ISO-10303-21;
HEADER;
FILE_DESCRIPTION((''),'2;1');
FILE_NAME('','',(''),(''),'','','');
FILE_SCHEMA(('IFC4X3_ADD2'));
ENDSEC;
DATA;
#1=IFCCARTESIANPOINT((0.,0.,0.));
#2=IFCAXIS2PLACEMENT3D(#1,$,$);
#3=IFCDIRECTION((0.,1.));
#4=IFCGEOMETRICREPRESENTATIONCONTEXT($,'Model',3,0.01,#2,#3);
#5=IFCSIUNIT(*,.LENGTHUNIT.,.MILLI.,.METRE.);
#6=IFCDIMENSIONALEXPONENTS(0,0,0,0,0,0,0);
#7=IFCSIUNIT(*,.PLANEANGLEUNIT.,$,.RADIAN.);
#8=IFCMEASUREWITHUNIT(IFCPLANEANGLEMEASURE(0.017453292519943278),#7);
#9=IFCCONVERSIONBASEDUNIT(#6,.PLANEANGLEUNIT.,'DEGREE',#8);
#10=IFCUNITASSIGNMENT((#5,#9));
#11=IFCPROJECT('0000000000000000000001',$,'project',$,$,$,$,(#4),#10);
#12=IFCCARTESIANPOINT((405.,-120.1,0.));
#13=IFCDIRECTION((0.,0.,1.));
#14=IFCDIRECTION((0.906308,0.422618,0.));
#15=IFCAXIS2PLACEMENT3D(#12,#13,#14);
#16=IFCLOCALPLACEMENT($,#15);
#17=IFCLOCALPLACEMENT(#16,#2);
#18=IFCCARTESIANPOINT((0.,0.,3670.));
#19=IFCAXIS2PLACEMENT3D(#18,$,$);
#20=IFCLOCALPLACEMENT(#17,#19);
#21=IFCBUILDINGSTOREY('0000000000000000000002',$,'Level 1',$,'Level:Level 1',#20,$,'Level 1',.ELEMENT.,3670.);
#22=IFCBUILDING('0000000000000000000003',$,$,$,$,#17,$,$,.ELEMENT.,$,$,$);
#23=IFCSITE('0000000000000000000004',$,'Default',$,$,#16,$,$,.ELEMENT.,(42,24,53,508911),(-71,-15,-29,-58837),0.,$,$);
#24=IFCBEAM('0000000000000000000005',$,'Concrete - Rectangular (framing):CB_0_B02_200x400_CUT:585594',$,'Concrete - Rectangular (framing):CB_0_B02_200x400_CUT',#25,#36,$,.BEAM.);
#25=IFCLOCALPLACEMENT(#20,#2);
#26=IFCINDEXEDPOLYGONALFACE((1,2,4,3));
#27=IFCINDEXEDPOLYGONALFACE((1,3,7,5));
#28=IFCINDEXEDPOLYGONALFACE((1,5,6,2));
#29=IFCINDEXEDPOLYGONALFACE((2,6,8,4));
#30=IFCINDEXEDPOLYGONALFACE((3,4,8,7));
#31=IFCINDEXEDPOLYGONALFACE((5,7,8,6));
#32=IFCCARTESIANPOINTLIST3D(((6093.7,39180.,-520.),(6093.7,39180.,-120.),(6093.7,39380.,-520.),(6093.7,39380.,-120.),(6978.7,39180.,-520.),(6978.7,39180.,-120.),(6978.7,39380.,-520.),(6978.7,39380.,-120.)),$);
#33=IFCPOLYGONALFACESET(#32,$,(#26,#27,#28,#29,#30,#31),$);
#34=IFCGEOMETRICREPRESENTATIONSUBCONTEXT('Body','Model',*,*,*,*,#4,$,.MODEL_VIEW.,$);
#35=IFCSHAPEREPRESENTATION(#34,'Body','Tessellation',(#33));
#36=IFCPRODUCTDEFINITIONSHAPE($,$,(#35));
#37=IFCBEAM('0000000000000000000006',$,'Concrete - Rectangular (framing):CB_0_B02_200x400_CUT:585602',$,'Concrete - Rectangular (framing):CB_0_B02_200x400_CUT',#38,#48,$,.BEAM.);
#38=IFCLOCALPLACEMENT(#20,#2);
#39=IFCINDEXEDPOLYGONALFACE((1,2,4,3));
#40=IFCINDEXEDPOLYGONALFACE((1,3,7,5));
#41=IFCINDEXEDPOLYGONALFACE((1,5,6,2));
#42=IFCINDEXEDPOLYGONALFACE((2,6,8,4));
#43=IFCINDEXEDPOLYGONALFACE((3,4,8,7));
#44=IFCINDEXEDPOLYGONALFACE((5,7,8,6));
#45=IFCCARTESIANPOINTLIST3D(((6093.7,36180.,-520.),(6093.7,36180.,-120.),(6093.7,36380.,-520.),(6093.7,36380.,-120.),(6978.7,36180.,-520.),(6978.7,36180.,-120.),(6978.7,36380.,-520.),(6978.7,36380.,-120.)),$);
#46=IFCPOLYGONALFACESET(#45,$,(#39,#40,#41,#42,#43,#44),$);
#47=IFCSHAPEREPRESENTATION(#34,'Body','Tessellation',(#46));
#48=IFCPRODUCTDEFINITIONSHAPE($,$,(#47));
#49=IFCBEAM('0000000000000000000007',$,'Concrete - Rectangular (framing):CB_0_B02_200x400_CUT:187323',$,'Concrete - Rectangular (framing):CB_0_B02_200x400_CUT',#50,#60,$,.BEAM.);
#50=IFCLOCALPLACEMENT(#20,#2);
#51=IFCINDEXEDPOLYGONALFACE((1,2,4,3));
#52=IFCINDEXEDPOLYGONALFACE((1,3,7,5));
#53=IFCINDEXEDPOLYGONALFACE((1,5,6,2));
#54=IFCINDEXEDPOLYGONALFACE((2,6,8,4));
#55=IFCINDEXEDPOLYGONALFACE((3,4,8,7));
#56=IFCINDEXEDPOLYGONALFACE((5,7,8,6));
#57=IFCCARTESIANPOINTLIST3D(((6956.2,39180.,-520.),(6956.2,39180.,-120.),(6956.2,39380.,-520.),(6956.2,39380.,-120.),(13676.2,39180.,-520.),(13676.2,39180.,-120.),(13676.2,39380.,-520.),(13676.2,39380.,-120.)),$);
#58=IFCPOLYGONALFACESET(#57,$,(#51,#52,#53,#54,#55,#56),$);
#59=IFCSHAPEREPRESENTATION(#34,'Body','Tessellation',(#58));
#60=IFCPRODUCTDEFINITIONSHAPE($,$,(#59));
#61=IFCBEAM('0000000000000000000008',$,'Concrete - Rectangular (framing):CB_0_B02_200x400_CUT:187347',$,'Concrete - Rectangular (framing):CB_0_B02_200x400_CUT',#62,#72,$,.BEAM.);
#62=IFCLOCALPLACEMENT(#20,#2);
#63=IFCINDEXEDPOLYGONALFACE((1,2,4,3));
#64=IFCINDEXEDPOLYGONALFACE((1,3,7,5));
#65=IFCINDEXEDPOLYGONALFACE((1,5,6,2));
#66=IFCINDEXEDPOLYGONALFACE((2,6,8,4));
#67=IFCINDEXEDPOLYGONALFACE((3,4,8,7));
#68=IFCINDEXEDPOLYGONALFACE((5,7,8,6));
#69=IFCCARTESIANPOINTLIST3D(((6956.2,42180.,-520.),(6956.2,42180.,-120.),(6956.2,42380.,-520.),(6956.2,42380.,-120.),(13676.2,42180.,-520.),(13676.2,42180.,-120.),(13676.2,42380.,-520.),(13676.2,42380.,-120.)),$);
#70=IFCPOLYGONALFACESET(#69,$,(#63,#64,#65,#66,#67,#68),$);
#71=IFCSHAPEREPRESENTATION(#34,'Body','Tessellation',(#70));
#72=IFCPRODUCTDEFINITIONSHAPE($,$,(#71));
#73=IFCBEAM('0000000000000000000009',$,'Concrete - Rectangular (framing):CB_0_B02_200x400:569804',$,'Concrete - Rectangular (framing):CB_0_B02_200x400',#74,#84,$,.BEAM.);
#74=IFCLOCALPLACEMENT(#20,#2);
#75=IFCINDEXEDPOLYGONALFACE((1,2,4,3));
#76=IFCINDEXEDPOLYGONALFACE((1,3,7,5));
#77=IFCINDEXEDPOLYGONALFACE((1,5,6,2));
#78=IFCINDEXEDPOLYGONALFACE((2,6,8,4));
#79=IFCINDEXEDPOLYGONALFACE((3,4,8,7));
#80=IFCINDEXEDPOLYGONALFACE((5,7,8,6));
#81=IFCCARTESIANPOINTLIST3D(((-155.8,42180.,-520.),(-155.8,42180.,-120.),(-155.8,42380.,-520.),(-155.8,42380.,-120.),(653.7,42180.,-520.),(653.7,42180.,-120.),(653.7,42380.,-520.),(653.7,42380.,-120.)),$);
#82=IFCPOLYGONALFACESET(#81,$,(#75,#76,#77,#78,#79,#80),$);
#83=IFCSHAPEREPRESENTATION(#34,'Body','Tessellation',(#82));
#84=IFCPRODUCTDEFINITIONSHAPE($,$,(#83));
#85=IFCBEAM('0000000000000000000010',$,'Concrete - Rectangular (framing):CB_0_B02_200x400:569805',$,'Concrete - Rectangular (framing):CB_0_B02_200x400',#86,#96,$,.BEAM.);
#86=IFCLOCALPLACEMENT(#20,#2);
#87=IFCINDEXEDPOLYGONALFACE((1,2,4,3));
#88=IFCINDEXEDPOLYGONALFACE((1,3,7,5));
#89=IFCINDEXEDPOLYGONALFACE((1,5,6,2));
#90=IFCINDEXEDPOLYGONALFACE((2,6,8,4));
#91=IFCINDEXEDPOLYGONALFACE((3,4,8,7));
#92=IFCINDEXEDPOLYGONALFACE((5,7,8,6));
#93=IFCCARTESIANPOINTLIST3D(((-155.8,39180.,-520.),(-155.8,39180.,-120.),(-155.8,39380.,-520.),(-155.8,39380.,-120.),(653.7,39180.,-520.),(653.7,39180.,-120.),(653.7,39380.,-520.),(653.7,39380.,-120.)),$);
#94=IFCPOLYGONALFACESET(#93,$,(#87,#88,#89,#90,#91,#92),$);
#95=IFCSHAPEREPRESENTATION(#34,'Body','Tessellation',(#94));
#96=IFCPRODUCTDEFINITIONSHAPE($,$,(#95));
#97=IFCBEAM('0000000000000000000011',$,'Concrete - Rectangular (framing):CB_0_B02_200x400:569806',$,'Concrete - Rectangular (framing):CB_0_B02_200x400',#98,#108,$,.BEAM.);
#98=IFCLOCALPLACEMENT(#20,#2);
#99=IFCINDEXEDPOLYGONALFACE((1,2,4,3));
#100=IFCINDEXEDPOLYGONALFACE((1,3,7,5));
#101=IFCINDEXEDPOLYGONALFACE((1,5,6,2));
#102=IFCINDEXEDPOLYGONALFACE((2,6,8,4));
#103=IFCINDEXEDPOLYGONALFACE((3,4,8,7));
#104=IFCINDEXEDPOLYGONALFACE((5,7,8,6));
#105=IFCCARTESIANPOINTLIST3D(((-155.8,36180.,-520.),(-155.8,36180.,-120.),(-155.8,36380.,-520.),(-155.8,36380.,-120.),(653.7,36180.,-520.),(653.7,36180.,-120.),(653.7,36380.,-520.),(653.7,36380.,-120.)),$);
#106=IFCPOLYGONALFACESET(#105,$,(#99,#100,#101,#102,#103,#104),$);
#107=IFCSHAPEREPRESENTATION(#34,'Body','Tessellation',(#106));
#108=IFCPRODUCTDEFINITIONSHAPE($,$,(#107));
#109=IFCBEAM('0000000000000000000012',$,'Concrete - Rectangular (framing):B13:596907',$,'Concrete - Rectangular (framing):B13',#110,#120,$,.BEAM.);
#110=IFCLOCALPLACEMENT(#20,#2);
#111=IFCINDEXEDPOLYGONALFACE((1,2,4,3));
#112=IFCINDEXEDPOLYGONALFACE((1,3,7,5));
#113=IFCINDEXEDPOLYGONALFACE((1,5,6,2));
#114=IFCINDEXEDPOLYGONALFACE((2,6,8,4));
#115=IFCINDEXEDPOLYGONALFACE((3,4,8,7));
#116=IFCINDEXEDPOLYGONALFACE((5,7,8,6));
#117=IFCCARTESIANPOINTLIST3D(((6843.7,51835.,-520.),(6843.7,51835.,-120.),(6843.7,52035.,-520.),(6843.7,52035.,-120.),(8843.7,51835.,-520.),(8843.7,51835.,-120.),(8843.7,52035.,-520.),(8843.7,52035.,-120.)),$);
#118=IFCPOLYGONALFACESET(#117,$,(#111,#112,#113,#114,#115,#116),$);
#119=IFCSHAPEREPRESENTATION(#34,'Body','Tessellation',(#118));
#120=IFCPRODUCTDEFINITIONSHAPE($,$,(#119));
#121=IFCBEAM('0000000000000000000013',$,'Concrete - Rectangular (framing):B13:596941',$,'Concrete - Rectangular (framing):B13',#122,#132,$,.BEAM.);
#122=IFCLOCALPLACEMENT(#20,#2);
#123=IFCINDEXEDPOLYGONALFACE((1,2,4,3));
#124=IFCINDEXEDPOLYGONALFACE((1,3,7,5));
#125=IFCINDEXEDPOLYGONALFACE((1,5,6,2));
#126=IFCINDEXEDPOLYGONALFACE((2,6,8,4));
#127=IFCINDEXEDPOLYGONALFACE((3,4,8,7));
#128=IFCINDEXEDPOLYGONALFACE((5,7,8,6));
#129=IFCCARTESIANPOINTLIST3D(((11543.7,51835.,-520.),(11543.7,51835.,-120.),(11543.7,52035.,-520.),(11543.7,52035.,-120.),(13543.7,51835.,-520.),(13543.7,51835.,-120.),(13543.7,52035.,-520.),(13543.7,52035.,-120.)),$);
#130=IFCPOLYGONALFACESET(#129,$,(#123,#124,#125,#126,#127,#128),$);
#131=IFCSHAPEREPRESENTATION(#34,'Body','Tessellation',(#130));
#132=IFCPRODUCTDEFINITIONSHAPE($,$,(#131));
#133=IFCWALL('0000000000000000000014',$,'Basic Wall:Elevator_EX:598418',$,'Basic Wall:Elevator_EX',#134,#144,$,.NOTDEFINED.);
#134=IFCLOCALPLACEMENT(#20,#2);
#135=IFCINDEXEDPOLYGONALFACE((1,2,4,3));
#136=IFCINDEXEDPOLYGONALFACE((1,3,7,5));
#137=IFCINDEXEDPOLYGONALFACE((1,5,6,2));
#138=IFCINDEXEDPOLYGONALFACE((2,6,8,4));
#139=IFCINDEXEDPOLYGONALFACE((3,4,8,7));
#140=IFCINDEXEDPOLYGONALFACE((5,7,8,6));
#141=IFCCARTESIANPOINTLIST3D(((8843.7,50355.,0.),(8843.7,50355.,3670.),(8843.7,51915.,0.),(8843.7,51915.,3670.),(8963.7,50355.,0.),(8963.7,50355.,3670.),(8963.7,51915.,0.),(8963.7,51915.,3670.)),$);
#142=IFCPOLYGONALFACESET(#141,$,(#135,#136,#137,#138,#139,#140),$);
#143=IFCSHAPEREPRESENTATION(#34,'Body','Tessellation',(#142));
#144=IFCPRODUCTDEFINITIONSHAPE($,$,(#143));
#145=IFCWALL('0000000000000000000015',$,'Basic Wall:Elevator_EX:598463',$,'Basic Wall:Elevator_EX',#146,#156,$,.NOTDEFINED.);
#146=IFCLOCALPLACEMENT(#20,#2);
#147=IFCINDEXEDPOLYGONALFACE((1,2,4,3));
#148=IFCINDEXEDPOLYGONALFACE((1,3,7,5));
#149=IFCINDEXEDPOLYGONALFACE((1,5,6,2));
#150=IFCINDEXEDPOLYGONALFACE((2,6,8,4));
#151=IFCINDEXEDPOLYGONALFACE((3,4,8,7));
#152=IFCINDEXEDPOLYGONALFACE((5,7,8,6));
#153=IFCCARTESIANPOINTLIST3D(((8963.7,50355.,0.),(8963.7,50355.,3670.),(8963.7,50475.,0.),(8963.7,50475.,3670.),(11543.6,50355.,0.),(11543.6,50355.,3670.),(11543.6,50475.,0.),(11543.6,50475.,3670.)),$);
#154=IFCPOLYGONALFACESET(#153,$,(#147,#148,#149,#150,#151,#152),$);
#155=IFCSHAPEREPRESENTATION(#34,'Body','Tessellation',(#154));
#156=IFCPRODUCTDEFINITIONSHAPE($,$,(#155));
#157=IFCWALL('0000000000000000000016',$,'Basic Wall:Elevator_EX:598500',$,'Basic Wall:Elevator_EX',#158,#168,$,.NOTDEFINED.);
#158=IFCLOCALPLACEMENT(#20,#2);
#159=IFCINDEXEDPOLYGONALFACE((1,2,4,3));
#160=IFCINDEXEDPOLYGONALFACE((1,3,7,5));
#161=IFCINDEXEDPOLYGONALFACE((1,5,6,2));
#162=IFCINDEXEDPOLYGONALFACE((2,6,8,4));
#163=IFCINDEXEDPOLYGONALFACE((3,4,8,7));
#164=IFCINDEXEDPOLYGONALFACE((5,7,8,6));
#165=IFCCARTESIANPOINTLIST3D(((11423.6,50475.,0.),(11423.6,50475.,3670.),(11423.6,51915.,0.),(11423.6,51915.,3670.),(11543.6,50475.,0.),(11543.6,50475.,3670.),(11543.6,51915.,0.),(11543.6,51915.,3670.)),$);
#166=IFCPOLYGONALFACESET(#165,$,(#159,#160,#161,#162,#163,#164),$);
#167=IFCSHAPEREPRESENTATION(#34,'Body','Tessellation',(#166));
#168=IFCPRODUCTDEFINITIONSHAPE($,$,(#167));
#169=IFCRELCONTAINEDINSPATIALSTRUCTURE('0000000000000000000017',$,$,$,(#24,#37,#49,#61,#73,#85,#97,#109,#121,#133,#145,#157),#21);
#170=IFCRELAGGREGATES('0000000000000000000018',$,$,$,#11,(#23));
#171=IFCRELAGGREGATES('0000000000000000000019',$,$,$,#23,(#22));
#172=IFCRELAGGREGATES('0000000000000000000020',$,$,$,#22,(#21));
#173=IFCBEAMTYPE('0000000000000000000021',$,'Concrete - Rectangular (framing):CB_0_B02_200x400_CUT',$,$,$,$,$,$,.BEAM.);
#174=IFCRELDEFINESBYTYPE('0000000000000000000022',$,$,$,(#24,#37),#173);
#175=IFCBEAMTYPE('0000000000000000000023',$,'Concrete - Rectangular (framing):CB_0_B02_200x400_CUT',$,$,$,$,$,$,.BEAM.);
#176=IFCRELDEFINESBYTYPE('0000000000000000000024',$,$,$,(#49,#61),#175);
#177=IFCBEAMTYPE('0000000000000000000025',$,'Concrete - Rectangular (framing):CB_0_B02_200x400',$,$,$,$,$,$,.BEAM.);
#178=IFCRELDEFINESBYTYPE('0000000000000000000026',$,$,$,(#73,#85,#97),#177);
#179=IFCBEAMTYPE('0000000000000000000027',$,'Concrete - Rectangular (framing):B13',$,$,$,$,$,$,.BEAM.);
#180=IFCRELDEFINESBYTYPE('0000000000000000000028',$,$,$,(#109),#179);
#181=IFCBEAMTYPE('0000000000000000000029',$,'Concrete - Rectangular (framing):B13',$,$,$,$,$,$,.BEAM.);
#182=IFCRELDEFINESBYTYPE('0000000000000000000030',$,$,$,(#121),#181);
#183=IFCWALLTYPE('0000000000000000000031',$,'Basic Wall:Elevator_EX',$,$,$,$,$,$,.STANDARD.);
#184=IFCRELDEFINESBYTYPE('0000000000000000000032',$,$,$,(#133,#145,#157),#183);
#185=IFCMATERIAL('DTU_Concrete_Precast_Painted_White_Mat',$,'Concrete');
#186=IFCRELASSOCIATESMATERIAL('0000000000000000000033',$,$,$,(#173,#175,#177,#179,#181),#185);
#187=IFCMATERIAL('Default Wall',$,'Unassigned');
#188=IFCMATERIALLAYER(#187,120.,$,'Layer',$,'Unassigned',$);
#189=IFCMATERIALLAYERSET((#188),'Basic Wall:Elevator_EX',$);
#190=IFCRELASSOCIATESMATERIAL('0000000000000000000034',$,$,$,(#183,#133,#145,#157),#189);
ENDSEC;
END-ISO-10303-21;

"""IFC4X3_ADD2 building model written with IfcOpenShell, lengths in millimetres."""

from ifc_helpers import new_model, entity, si_unit, converted_unit, direction, frame, frame_2d, origin, origin_2d_with_axis, place, context, subcontext, project, spatial, rectangle, extrude, source, transform, mapped, material, layer, layer_set, material_profile, profile_set, type_object, type_shapes, element, save


model = new_model("IFC4X3_ADD2")

# Units and contexts
model_context = context("Model", 3, precision=0.01, world=origin(), true_north=direction((0.0, 1.0)))
body_context = subcontext(model_context, "Body", "Model", "MODEL_VIEW")
ifc_project = project(units=[si_unit("LENGTHUNIT", "METRE", prefix="MILLI"), converted_unit("PLANEANGLEUNIT", "DEGREE", entity("IfcPlaneAngleMeasure", 0.017453292519943278), si_unit("PLANEANGLEUNIT", "RADIAN"), dimensions=[0, 0, 0, 0, 0, 0, 0])], contexts=[model_context])

# Site, building, storey
site_placement = place(None, frame((405.0, -120.1, 0.0), z_axis=(0.0, 0.0, 1.0), x_axis=(0.906308, 0.422618, 0.0)))
site = spatial("IfcSite", under=ifc_project, at=site_placement, Name="Default", CompositionType="ELEMENT", RefLatitude=(42, 24, 53, 508911), RefLongitude=(-71, -15, -29, -58837), RefElevation=0.0)
building_placement = place(site_placement, origin())
building = spatial("IfcBuilding", under=site, at=building_placement, CompositionType="ELEMENT")
storey_placement = place(building_placement, frame((0.0, 0.0, 3670.0)))
storey = spatial("IfcBuildingStorey", under=building, at=storey_placement, Name="Level 1", ObjectType="Level:Level 1", LongName="Level 1", CompositionType="ELEMENT", Elevation=3670.0)

# Beams
ifc_material_1 = material(Name="DTU_Concrete_Precast_Painted_White_Mat", Category="Concrete")
ifc_material_profile_1 = material_profile(ifc_material_1, rectangle(XDim=7035.5, YDim=200.0, at=frame_2d((0.0, 0.0), x_axis=(1.0, 0.0))), Name="CB_0_B02_200x400")
ifc_profile_set_1 = profile_set([ifc_material_profile_1], Name="CB_0_B02_200x400")
ifc_material_profile_2 = material_profile(ifc_material_1, rectangle(XDim=885.0, YDim=200.0, at=origin_2d_with_axis()), Name="CB_0_B02_200x400_CUT")
ifc_profile_set_2 = profile_set([ifc_material_profile_2], Name="CB_0_B02_200x400_CUT")
beam_type_1 = type_object("IfcBeamType", Name="Concrete - Rectangular (framing):CB_0_B02_200x400_CUT", PredefinedType="BEAM", material=ifc_profile_set_2)
shared_shape_1 = source(origin(), body_context, "Body", "SweptSolid", [
    extrude(rectangle(XDim=885.0, YDim=200.0, at=origin_2d_with_axis()), frame((0.0, 0.0, -200.0), z_axis=(0.0, 0.0, 1.0), x_axis=(-1.0, 0.0, 0.0)), (0.0, 0.0, 1.0), 400.0),
])
type_shapes(beam_type_1, [shared_shape_1])
for number, where, z_axis, x_axis, name in (
    (1, (6536.2, 39280.0, -320.0), (0.0, 0.0, 1.0), (-1.0, 0.0, 0.0), "Concrete - Rectangular (framing):CB_0_B02_200x400_CUT:585594"),
    (2, (6536.2, 36280.0, -320.0), (0.0, 0.0, 1.0), (-1.0, 0.0, 0.0), "Concrete - Rectangular (framing):CB_0_B02_200x400_CUT:585602"),
):
    element("IfcBeam", number, at=place(storey_placement, frame(where, z_axis=z_axis, x_axis=x_axis)), inside=storey, type_object=beam_type_1, Name=name, ObjectType="Concrete - Rectangular (framing):CB_0_B02_200x400_CUT", PredefinedType="BEAM", context=body_context, shape_type="MappedRepresentation", body=[
        mapped(shared_shape_1, transform((0.0, 0.0, 0.0), scale=1.0)),
    ])
beam_type_2 = type_object("IfcBeamType", Name="Concrete - Rectangular (framing):CB_0_B02_200x400_CUT", PredefinedType="BEAM", material=ifc_profile_set_2)
shared_shape_2 = source(origin(), body_context, "Body", "SweptSolid", [
    extrude(rectangle(XDim=6720.0, YDim=200.0, at=origin_2d_with_axis()), frame((0.0, 0.0, -200.0), z_axis=(0.0, 0.0, 1.0), x_axis=(-1.0, 0.0, 0.0)), (0.0, 0.0, 1.0), 400.0),
])
type_shapes(beam_type_2, [shared_shape_2])
for number, where, name in (
    (3, (10316.2, 39280.0, -320.0), "Concrete - Rectangular (framing):CB_0_B02_200x400_CUT:187323"),
    (4, (10316.2, 42280.0, -320.0), "Concrete - Rectangular (framing):CB_0_B02_200x400_CUT:187347"),
):
    element("IfcBeam", number, at=place(storey_placement, frame(where)), inside=storey, type_object=beam_type_2, Name=name, ObjectType="Concrete - Rectangular (framing):CB_0_B02_200x400_CUT", PredefinedType="BEAM", context=body_context, shape_type="MappedRepresentation", body=[
        mapped(shared_shape_2, transform((0.0, 0.0, 0.0), scale=1.0)),
    ])
beam_type_3 = type_object("IfcBeamType", Name="Concrete - Rectangular (framing):CB_0_B02_200x400", PredefinedType="BEAM", material=ifc_profile_set_1)
shared_shape_3 = source(origin(), body_context, "Body", "SweptSolid", [
    extrude(rectangle(XDim=200.0, YDim=809.5, at=origin_2d_with_axis()), frame((-200.0, 0.0, -200.0), z_axis=(0.0, 0.0, 1.0), x_axis=(0.0, 1.0, 0.0)), (0.0, 0.0, 1.0), 400.0),
])
type_shapes(beam_type_3, [shared_shape_3])
for number, where, z_axis, x_axis, name in (
    (5, (49.0, 42280.0, -320.0), (0.0, 0.0, 1.0), (-1.0, 0.0, 0.0), "Concrete - Rectangular (framing):CB_0_B02_200x400:569804"),
    (6, (49.0, 39280.0, -320.0), (0.0, 0.0, 1.0), (-1.0, 0.0, 0.0), "Concrete - Rectangular (framing):CB_0_B02_200x400:569805"),
    (7, (49.0, 36280.0, -320.0), (0.0, 0.0, 1.0), (-1.0, 0.0, 0.0), "Concrete - Rectangular (framing):CB_0_B02_200x400:569806"),
):
    element("IfcBeam", number, at=place(storey_placement, frame(where, z_axis=z_axis, x_axis=x_axis)), inside=storey, type_object=beam_type_3, Name=name, ObjectType="Concrete - Rectangular (framing):CB_0_B02_200x400", PredefinedType="BEAM", context=body_context, shape_type="MappedRepresentation", body=[
        mapped(shared_shape_3, transform((0.0, 0.0, 0.0), scale=1.0)),
    ])
ifc_material_profile_3 = material_profile(ifc_material_1, rectangle(XDim=2000.0, YDim=200.0, at=origin_2d_with_axis()), Name="B13")
ifc_profile_set_3 = profile_set([ifc_material_profile_3], Name="B13")
beam_type_4 = type_object("IfcBeamType", Name="Concrete - Rectangular (framing):B13", PredefinedType="BEAM", material=ifc_profile_set_3)
shared_shape_4 = source(origin(), body_context, "Body", "SweptSolid", [
    extrude(rectangle(XDim=2000.0, YDim=200.0, at=origin_2d_with_axis()), frame((-7.5, 0.0, -200.0), z_axis=(0.0, 0.0, 1.0), x_axis=(-1.0, 0.0, 0.0)), (0.0, 0.0, 1.0), 400.0),
])
type_shapes(beam_type_4, [shared_shape_4])
beam_1_placement = place(storey_placement, frame((7836.2, 51935.0, -320.0), z_axis=(0.0, 0.0, 1.0), x_axis=(-1.0, 0.0, 0.0)))
element("IfcBeam", 8, at=beam_1_placement, inside=storey, type_object=beam_type_4, Name="Concrete - Rectangular (framing):B13:596907", ObjectType="Concrete - Rectangular (framing):B13", PredefinedType="BEAM", context=body_context, shape_type="MappedRepresentation", body=[
    mapped(shared_shape_4, transform((0.0, 0.0, 0.0), scale=1.0)),
])
beam_type_5 = type_object("IfcBeamType", Name="Concrete - Rectangular (framing):B13", PredefinedType="BEAM", material=ifc_profile_set_3)
shared_shape_5 = source(origin(), body_context, "Body", "SweptSolid", [
    extrude(rectangle(XDim=2000.0, YDim=200.0, at=origin_2d_with_axis()), frame((-175.0, 0.0, -200.0), z_axis=(0.0, 0.0, 1.0), x_axis=(-1.0, 0.0, 0.0)), (0.0, 0.0, 1.0), 400.0),
])
type_shapes(beam_type_5, [shared_shape_5])
beam_2_placement = place(storey_placement, frame((12368.7, 51935.0, -320.0), z_axis=(0.0, 0.0, 1.0), x_axis=(-1.0, 0.0, 0.0)))
element("IfcBeam", 9, at=beam_2_placement, inside=storey, type_object=beam_type_5, Name="Concrete - Rectangular (framing):B13:596941", ObjectType="Concrete - Rectangular (framing):B13", PredefinedType="BEAM", context=body_context, shape_type="MappedRepresentation", body=[
    mapped(shared_shape_5, transform((0.0, 0.0, 0.0), scale=1.0)),
])

# Walls
ifc_material_2 = material(Name="Default Wall", Category="Unassigned")
ifc_layer = layer(ifc_material_2, 120.0, Name="Layer", Category="Unassigned")
ifc_layer_set = layer_set([ifc_layer], Name="Basic Wall:Elevator_EX")
wall_type = type_object("IfcWallType", Name="Basic Wall:Elevator_EX", PredefinedType="STANDARD", material=ifc_layer_set)
wall_1_placement = place(storey_placement, frame((8903.7, 51915.0, 0.0), z_axis=(0.0, 0.0, 1.0), x_axis=(0.0, -1.0, 0.0)))
element("IfcWall", 10, at=wall_1_placement, inside=storey, type_object=wall_type, material=ifc_layer_set, Name="Basic Wall:Elevator_EX:598418", ObjectType="Basic Wall:Elevator_EX", PredefinedType="NOTDEFINED", context=body_context, shape_type="SweptSolid", body=[
    extrude(rectangle(XDim=1560.0, YDim=120.0, at=frame_2d((780.0, 0.0), x_axis=(-1.0, 0.0))), origin(), (0.0, 0.0, 1.0), 3670.0),
])
wall_2_placement = place(storey_placement, frame((8963.7, 50415.0, 0.0)))
element("IfcWall", 11, at=wall_2_placement, inside=storey, type_object=wall_type, material=ifc_layer_set, Name="Basic Wall:Elevator_EX:598463", ObjectType="Basic Wall:Elevator_EX", PredefinedType="NOTDEFINED", context=body_context, shape_type="SweptSolid", body=[
    extrude(rectangle(XDim=2579.9, YDim=120.0, at=frame_2d((1289.9, 0.0), x_axis=(-1.0, 0.0))), origin(), (0.0, 0.0, 1.0), 3670.0),
])
wall_3_placement = place(storey_placement, frame((11483.6, 50475.0, 0.0), z_axis=(0.0, 0.0, 1.0), x_axis=(0.0, 1.0, 0.0)))
element("IfcWall", 12, at=wall_3_placement, inside=storey, type_object=wall_type, material=ifc_layer_set, Name="Basic Wall:Elevator_EX:598500", ObjectType="Basic Wall:Elevator_EX", PredefinedType="NOTDEFINED", context=body_context, shape_type="SweptSolid", body=[
    extrude(rectangle(XDim=1440.0, YDim=120.0, at=frame_2d((720.0, 0.0), x_axis=(-1.0, 0.0))), origin(), (0.0, 0.0, 1.0), 3670.0),
])

save(model, "model.ifc")
